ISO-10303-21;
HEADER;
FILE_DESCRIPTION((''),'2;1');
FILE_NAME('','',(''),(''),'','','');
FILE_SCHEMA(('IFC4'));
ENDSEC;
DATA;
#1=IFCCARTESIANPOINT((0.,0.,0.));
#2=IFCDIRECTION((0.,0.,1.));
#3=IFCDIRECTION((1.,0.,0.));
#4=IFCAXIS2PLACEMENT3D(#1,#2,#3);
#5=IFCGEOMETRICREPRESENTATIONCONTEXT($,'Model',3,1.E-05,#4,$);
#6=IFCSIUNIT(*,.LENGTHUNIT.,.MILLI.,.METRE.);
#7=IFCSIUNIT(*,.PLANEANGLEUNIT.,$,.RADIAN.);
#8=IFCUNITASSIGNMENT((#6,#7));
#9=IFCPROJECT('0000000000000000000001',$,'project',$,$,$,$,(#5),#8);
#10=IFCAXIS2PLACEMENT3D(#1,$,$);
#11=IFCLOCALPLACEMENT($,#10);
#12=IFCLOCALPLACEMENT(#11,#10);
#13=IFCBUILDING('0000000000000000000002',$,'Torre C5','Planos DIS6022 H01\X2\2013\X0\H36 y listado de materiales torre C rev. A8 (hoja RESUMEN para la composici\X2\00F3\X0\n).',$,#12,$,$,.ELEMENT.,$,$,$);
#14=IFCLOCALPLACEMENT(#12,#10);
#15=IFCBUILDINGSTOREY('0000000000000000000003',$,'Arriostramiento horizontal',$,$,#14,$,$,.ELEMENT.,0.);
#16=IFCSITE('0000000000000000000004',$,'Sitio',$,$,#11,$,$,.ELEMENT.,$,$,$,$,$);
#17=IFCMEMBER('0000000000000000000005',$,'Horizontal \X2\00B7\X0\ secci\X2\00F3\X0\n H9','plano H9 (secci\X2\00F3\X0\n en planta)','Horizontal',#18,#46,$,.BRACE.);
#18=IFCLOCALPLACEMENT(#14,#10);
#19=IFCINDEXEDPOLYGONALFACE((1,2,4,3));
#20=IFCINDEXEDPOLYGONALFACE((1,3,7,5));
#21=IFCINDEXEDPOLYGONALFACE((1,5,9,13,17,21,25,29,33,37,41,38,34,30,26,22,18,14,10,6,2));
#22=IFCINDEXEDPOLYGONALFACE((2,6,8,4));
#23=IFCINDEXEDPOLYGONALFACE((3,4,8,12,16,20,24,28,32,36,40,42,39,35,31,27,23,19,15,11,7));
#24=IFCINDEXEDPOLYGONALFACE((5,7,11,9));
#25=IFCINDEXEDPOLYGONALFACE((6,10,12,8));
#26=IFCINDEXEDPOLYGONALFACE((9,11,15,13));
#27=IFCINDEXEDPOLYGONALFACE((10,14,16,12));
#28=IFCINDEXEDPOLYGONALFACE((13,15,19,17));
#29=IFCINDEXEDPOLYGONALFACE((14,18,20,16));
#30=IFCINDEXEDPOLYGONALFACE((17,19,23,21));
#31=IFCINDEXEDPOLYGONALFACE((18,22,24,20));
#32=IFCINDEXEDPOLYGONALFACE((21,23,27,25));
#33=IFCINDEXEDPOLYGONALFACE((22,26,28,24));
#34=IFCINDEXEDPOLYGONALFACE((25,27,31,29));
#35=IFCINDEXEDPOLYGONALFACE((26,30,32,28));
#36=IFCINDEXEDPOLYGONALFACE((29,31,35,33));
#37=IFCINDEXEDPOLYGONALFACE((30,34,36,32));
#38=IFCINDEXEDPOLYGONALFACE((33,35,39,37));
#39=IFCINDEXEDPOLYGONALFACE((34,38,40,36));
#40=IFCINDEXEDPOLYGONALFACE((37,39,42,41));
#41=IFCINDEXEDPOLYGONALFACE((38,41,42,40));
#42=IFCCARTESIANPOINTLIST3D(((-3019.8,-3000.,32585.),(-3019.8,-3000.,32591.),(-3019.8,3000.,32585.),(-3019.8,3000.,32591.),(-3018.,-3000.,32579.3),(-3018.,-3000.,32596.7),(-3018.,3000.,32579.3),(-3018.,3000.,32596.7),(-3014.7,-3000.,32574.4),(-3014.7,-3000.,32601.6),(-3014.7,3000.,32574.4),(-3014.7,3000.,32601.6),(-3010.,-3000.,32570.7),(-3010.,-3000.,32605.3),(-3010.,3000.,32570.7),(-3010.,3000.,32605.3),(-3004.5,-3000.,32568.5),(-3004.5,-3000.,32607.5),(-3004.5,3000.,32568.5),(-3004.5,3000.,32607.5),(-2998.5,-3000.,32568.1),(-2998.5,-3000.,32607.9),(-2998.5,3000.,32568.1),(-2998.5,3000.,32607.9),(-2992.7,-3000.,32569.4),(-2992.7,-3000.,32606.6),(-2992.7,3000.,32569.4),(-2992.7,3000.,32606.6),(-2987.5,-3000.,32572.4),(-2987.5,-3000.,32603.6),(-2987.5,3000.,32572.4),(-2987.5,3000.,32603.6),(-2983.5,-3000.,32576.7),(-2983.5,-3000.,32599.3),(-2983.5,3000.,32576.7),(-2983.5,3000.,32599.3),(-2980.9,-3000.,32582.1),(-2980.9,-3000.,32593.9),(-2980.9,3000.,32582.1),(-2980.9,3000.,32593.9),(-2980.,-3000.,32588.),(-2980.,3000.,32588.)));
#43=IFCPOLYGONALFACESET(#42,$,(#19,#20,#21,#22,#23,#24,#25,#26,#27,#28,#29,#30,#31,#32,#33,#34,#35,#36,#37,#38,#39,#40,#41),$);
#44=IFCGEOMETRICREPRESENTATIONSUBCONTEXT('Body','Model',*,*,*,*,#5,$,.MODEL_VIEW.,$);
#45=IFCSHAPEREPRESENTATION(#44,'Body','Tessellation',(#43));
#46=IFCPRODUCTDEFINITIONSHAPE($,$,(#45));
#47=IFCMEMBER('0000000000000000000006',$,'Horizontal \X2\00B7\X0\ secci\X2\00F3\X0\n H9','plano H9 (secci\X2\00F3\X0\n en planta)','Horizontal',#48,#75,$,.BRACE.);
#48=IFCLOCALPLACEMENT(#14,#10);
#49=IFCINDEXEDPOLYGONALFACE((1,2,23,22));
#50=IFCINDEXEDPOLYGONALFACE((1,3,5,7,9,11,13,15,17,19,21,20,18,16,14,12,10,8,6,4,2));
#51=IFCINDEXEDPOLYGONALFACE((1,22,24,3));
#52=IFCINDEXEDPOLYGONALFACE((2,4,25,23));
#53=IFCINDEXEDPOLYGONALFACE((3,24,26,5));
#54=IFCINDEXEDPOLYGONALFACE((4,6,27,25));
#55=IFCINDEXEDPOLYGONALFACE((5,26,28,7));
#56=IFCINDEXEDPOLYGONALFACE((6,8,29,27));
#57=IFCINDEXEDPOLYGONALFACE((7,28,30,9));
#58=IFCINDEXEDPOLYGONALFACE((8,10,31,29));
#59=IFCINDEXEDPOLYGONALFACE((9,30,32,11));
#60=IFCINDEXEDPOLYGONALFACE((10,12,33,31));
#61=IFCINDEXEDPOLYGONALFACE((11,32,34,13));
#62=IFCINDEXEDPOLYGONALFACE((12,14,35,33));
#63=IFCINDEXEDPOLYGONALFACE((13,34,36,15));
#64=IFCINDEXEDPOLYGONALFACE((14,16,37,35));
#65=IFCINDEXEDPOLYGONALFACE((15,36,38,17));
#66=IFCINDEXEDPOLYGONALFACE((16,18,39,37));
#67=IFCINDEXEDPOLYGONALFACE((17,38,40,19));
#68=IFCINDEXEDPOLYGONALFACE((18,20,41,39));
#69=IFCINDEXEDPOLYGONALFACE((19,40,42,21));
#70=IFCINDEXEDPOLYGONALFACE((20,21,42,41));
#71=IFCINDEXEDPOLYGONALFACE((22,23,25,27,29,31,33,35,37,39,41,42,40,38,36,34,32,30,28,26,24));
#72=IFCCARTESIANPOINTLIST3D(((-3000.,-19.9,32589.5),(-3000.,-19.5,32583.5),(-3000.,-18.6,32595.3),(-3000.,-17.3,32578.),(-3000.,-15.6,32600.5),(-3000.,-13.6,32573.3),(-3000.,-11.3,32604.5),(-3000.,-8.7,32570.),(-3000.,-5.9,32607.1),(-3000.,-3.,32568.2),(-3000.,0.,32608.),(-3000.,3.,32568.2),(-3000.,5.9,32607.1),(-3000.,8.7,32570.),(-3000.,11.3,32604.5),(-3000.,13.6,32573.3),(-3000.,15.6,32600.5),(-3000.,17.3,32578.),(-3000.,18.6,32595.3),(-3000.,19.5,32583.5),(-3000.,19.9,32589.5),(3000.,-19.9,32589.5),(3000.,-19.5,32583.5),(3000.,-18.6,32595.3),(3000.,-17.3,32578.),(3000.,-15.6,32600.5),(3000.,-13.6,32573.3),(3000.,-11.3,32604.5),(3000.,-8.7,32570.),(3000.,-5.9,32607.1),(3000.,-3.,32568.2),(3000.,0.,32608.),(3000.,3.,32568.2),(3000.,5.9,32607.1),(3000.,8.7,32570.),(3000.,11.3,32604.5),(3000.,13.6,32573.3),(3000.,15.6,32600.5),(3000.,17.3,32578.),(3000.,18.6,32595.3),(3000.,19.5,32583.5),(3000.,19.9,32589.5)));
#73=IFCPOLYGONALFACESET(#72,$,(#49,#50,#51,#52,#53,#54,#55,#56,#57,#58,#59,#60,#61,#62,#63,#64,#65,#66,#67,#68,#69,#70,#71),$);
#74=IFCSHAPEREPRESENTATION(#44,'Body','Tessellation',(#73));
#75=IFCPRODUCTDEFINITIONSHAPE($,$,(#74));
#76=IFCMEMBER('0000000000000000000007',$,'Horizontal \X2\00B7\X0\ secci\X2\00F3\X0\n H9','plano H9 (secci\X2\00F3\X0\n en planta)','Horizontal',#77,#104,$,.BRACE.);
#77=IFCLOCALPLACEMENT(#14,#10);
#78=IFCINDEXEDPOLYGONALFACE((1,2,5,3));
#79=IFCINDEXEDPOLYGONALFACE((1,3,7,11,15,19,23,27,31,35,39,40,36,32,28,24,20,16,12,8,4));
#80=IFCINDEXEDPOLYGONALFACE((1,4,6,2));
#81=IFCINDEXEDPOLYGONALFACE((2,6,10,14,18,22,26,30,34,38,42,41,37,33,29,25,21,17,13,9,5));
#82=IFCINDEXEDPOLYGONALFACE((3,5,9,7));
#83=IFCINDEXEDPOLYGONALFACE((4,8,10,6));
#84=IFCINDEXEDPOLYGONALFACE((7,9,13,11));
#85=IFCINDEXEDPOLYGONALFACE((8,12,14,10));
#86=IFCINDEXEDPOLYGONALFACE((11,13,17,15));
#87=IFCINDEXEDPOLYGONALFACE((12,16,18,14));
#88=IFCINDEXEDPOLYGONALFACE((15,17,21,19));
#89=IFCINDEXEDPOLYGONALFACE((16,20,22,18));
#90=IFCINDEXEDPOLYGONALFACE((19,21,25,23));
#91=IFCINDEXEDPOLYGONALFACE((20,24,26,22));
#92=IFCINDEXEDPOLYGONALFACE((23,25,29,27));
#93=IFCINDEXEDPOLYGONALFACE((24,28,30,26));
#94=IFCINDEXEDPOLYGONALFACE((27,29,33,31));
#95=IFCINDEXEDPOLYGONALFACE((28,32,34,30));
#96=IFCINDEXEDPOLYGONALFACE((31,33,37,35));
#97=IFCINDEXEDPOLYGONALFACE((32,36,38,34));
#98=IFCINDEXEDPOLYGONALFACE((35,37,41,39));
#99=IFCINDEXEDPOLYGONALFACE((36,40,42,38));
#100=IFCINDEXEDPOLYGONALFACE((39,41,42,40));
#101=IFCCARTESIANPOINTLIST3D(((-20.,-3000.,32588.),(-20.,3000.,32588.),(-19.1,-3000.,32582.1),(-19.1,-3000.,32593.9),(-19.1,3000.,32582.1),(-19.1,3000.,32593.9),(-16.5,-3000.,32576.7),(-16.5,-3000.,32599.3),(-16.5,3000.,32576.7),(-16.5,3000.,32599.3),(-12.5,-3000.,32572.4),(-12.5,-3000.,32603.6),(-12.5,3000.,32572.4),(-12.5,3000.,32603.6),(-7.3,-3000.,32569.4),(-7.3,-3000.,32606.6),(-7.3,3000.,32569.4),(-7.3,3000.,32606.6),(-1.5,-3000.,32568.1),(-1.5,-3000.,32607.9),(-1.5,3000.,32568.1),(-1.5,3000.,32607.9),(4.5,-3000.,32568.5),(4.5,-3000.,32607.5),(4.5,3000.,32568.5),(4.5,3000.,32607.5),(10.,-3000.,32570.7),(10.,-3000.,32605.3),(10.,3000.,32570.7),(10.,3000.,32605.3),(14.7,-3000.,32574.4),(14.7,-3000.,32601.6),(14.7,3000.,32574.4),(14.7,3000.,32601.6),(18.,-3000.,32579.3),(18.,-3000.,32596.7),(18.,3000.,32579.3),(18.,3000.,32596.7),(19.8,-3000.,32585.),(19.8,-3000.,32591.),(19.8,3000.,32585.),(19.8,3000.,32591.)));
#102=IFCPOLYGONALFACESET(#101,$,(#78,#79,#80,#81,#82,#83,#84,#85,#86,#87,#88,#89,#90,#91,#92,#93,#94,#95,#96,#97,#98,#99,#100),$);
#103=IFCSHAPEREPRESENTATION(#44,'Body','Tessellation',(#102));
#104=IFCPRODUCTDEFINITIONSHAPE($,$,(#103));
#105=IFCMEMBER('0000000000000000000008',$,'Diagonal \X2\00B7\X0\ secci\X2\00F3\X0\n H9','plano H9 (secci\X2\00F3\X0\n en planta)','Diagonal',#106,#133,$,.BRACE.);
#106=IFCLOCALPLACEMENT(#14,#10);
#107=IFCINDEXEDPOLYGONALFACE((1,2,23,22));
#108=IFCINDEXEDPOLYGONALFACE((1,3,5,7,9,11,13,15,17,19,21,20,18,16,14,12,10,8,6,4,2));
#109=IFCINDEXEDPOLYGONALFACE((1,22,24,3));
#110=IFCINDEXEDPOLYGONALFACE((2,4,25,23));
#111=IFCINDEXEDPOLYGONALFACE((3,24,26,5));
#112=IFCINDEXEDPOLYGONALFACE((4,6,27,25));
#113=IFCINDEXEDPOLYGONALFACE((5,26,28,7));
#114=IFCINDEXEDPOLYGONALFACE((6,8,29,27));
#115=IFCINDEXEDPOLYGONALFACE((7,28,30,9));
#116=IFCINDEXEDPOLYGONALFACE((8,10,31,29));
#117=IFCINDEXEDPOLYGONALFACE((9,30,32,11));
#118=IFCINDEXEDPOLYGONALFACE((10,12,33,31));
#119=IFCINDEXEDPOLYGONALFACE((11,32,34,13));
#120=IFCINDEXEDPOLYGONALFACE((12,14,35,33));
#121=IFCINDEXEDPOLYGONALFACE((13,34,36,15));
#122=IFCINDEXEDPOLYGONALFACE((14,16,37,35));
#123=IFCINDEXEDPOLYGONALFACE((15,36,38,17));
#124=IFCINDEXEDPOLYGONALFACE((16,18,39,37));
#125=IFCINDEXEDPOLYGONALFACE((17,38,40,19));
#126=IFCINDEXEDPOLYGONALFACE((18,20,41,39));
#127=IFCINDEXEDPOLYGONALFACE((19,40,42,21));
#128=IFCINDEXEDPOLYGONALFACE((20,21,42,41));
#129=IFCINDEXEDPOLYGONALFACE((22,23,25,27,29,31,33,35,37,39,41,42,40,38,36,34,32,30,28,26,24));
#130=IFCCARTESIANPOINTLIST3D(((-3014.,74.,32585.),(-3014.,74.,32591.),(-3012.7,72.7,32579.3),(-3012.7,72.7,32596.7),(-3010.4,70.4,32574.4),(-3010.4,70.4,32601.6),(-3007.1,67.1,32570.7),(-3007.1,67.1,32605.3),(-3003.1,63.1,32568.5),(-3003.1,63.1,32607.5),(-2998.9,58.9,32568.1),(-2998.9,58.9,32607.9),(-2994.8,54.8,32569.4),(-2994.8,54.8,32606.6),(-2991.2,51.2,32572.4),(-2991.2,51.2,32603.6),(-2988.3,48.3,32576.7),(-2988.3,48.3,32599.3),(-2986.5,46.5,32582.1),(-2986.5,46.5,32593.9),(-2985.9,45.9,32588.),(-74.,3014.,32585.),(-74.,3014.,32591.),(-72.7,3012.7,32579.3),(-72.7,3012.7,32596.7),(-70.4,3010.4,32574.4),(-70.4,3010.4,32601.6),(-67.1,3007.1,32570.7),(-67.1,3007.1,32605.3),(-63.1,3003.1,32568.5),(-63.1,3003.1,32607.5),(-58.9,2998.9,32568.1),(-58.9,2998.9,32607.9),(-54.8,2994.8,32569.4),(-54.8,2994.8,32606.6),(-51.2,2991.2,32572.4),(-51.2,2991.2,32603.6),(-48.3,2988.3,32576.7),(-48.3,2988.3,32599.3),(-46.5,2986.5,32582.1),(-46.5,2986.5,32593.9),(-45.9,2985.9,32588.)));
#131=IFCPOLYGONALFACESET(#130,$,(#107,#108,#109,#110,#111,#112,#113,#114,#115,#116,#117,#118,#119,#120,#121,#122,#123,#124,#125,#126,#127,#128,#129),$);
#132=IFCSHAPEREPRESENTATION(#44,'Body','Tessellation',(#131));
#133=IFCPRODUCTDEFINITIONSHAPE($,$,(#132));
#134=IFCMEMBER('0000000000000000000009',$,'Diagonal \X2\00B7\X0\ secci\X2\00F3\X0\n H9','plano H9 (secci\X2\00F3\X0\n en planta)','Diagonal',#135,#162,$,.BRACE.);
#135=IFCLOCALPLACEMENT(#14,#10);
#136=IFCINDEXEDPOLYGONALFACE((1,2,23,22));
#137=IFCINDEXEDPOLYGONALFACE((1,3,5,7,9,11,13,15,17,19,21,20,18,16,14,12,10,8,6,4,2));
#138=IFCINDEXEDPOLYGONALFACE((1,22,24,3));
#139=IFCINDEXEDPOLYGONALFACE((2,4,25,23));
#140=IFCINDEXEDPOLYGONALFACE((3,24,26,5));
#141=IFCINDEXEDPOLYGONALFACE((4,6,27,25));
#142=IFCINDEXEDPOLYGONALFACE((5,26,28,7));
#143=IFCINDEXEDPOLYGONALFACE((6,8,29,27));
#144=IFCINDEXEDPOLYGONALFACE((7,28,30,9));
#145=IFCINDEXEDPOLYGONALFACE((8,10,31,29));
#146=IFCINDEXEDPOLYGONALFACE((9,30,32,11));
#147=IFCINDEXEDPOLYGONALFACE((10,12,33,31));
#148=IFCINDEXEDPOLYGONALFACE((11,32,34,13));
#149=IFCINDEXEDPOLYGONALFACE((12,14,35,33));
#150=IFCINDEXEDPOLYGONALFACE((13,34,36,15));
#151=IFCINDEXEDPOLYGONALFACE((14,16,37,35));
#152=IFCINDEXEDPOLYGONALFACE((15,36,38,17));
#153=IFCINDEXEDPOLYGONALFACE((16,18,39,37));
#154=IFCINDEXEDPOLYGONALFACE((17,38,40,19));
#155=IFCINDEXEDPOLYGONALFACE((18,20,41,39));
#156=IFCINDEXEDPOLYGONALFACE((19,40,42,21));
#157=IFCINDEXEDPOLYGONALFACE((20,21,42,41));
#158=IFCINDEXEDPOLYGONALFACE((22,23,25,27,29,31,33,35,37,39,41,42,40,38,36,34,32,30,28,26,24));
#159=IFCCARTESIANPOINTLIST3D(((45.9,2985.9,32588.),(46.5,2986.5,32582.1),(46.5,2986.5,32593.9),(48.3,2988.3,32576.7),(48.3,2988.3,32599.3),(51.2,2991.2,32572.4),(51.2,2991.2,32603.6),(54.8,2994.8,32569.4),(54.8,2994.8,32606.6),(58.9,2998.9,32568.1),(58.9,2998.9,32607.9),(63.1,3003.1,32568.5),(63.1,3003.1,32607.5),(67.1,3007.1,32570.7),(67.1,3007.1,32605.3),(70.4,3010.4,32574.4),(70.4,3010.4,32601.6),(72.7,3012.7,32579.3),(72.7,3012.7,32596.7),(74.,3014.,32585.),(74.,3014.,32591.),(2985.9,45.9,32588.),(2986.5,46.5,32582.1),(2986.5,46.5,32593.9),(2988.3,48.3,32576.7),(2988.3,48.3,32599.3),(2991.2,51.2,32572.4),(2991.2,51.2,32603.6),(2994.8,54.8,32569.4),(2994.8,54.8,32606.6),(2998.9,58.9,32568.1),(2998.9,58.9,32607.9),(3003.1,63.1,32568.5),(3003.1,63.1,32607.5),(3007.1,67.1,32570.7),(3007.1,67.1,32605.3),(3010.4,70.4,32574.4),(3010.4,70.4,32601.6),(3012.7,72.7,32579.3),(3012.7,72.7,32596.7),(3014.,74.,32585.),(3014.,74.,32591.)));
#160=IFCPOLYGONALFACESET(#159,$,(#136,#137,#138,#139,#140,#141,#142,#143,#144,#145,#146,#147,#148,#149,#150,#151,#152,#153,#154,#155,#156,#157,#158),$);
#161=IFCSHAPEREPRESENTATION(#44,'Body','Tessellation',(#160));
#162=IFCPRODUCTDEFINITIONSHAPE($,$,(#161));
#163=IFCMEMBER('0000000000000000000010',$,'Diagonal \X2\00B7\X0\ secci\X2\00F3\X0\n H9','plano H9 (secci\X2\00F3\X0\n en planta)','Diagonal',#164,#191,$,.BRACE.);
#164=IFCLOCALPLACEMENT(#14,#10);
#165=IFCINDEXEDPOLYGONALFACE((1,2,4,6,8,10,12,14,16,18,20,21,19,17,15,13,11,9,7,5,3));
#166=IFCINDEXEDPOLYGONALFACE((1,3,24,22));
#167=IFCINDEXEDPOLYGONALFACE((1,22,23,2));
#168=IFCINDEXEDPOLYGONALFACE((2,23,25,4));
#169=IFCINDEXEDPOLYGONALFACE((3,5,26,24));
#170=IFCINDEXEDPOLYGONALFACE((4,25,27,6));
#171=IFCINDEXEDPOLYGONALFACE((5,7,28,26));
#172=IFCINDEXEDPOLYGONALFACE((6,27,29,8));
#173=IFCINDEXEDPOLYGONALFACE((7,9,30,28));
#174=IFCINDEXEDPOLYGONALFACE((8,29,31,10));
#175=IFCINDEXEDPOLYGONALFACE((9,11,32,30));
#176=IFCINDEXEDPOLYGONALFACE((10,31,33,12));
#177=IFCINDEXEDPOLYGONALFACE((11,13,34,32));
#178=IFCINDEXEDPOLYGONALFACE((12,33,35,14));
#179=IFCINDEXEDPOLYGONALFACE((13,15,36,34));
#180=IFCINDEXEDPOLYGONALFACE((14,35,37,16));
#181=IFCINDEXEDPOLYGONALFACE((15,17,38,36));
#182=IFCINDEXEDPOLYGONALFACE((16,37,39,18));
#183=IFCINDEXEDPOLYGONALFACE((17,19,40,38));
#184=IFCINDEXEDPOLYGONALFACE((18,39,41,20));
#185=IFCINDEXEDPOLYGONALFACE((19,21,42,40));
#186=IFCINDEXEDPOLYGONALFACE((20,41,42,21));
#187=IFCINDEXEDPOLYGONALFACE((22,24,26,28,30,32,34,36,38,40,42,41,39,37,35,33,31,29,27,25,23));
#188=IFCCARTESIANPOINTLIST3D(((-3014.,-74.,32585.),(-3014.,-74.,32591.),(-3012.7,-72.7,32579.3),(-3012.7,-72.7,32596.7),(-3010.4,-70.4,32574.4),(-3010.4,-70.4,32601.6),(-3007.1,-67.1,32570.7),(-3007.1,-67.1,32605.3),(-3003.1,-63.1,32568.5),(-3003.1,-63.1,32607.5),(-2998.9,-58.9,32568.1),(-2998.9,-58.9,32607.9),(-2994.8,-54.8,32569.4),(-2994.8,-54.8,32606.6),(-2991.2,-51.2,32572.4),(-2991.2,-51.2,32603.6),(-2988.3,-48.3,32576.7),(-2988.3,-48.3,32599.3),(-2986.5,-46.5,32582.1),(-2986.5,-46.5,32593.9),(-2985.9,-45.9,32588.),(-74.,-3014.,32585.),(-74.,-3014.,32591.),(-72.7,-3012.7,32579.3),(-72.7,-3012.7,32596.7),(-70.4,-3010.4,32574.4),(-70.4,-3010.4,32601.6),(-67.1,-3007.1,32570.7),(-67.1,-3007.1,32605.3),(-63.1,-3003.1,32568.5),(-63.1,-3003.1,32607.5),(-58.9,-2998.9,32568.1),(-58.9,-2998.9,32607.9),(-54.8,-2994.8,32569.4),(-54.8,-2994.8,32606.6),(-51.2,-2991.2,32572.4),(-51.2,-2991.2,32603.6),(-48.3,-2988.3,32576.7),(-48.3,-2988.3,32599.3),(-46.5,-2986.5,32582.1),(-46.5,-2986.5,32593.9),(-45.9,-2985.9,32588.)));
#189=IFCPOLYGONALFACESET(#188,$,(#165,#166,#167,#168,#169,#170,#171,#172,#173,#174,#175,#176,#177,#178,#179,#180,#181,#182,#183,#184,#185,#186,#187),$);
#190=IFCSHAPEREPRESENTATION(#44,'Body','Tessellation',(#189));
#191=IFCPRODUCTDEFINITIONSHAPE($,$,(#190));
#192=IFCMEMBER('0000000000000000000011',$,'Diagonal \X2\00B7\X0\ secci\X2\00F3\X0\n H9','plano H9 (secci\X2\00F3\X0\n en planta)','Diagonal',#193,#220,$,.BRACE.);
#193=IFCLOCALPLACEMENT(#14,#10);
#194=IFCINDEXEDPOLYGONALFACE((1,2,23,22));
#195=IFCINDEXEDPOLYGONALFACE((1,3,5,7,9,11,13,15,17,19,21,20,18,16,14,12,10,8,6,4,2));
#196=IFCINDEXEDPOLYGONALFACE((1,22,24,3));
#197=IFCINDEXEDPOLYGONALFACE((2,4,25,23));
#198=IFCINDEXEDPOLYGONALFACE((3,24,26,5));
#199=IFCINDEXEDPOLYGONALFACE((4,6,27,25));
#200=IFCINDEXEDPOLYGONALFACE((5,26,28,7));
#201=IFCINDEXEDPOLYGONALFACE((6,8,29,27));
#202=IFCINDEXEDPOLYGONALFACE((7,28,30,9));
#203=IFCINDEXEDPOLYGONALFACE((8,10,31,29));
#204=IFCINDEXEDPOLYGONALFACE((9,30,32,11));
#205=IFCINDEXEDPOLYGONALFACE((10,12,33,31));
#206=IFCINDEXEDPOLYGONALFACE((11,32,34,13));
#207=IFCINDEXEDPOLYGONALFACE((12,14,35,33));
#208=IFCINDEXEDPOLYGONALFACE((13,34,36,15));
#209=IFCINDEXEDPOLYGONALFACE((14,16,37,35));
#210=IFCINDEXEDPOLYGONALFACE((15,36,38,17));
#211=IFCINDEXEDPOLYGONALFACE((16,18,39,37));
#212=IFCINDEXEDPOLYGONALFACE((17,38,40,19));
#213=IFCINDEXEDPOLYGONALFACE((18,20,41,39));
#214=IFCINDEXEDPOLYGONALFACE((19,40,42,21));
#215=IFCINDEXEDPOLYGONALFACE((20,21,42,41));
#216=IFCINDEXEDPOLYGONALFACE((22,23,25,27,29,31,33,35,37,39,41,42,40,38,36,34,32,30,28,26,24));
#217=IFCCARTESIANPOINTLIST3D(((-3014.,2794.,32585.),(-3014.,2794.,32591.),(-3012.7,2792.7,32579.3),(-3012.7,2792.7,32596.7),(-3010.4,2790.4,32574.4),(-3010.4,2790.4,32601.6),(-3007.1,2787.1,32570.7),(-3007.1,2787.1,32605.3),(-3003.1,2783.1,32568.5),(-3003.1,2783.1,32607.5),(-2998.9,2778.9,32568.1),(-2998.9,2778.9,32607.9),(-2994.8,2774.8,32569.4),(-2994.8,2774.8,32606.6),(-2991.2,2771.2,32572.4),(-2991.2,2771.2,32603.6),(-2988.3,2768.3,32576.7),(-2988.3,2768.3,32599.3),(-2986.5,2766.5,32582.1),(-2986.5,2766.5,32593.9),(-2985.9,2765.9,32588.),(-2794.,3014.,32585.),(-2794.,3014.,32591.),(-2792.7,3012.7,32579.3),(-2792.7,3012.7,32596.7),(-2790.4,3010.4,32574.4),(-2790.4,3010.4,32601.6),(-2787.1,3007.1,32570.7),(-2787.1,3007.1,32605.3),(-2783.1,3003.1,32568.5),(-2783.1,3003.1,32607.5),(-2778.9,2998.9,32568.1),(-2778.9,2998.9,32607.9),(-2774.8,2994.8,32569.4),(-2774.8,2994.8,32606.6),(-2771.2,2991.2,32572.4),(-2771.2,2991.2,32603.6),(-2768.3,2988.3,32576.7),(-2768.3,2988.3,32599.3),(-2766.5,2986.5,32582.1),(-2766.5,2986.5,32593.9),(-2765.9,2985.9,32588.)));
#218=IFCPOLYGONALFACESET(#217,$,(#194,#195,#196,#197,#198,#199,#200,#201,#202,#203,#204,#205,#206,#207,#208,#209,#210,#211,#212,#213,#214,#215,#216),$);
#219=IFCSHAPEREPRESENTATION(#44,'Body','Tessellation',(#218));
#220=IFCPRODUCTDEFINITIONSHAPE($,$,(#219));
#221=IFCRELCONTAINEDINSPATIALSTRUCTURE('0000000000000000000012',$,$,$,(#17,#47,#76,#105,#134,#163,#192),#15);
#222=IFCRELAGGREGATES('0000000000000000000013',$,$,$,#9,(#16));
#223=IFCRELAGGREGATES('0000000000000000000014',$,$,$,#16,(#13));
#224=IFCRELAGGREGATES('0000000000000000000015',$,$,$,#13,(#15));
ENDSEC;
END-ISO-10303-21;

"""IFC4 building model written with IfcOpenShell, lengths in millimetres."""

from ifc_helpers import new_model, si_unit, frame, origin, origin_with_axes, place, context, subcontext, project, spatial, circle, extrude, element, save


model = new_model("IFC4")

# Units and contexts
model_context = context("Model", 3, precision=1e-05, world=origin_with_axes())
body_context = subcontext(model_context, "Body", "Model", "MODEL_VIEW")
ifc_project = project(units=[si_unit("LENGTHUNIT", "METRE", prefix="MILLI"), si_unit("PLANEANGLEUNIT", "RADIAN")], contexts=[model_context])

# Site, building, storey
site_placement = place(None, origin())
site = spatial("IfcSite", under=ifc_project, at=site_placement, Name="Sitio", CompositionType="ELEMENT")
building_placement = place(site_placement, origin())
building = spatial("IfcBuilding", under=site, at=building_placement, Name="Torre C5", Description="Planos DIS6022 H01–H36 y listado de materiales torre C rev. A8 (hoja RESUMEN para la composición).", CompositionType="ELEMENT")
storey_placement = place(building_placement, origin())
storey = spatial("IfcBuildingStorey", under=building, at=storey_placement, Name="Arriostramiento horizontal", CompositionType="ELEMENT", Elevation=0.0)

# Members
for number, where, z_axis, x_axis, name in (
    (1, (-3000.0, 3000.0, 32588.0), (0.0, -1.0, 0.0), (1.0, 0.0, 0.0), "Horizontal · sección H9"),
    (2, (-3000.0, 0.0, 32588.0), (1.0, 0.0, 0.0), (0.0, 0.0, 1.0), "Horizontal · sección H9"),
    (3, (0.0, 3000.0, 32588.0), (0.0, -1.0, 0.0), (-1.0, 0.0, 0.0), "Horizontal · sección H9"),
):
    element("IfcMember", number, at=place(storey_placement, frame(where, z_axis=z_axis, x_axis=x_axis)), inside=storey, Name=name, Description="plano H9 (sección en planta)", ObjectType="Horizontal", PredefinedType="BRACE", context=body_context, shape_type="SweptSolid", body=[
        extrude(circle(Radius=20.0), None, (0.0, 0.0, 1.0), 6000.0),
    ])
for number, where, z_axis, x_axis, name in (
    (4, (-3000.0, 60.0, 32588.0), (0.707107, 0.707107, 0.0), (0.707107, -0.707107, 0.0), "Diagonal · sección H9"),
    (5, (60.0, 3000.0, 32588.0), (0.707107, -0.707107, 0.0), (-0.707107, -0.707107, 0.0), "Diagonal · sección H9"),
    (6, (-60.0, -3000.0, 32588.0), (-0.707107, 0.707107, 0.0), (0.707107, 0.707107, 0.0), "Diagonal · sección H9"),
):
    element("IfcMember", number, at=place(storey_placement, frame(where, z_axis=z_axis, x_axis=x_axis)), inside=storey, Name=name, Description="plano H9 (sección en planta)", ObjectType="Diagonal", PredefinedType="BRACE", context=body_context, shape_type="SweptSolid", body=[
        extrude(circle(Radius=20.0), None, (0.0, 0.0, 1.0), 4157.8),
    ])
member_1_placement = place(storey_placement, frame((-2780.0, 3000.0, 32588.0), z_axis=(-0.707107, -0.707107, 0.0), x_axis=(0.707107, -0.707107, 0.0)))
element("IfcMember", 7, at=member_1_placement, inside=storey, Name="Diagonal · sección H9", Description="plano H9 (sección en planta)", ObjectType="Diagonal", PredefinedType="BRACE", context=body_context, shape_type="SweptSolid", body=[
    extrude(circle(Radius=20.0), None, (0.0, 0.0, 1.0), 311.1),
])

save(model, "model.ifc")
